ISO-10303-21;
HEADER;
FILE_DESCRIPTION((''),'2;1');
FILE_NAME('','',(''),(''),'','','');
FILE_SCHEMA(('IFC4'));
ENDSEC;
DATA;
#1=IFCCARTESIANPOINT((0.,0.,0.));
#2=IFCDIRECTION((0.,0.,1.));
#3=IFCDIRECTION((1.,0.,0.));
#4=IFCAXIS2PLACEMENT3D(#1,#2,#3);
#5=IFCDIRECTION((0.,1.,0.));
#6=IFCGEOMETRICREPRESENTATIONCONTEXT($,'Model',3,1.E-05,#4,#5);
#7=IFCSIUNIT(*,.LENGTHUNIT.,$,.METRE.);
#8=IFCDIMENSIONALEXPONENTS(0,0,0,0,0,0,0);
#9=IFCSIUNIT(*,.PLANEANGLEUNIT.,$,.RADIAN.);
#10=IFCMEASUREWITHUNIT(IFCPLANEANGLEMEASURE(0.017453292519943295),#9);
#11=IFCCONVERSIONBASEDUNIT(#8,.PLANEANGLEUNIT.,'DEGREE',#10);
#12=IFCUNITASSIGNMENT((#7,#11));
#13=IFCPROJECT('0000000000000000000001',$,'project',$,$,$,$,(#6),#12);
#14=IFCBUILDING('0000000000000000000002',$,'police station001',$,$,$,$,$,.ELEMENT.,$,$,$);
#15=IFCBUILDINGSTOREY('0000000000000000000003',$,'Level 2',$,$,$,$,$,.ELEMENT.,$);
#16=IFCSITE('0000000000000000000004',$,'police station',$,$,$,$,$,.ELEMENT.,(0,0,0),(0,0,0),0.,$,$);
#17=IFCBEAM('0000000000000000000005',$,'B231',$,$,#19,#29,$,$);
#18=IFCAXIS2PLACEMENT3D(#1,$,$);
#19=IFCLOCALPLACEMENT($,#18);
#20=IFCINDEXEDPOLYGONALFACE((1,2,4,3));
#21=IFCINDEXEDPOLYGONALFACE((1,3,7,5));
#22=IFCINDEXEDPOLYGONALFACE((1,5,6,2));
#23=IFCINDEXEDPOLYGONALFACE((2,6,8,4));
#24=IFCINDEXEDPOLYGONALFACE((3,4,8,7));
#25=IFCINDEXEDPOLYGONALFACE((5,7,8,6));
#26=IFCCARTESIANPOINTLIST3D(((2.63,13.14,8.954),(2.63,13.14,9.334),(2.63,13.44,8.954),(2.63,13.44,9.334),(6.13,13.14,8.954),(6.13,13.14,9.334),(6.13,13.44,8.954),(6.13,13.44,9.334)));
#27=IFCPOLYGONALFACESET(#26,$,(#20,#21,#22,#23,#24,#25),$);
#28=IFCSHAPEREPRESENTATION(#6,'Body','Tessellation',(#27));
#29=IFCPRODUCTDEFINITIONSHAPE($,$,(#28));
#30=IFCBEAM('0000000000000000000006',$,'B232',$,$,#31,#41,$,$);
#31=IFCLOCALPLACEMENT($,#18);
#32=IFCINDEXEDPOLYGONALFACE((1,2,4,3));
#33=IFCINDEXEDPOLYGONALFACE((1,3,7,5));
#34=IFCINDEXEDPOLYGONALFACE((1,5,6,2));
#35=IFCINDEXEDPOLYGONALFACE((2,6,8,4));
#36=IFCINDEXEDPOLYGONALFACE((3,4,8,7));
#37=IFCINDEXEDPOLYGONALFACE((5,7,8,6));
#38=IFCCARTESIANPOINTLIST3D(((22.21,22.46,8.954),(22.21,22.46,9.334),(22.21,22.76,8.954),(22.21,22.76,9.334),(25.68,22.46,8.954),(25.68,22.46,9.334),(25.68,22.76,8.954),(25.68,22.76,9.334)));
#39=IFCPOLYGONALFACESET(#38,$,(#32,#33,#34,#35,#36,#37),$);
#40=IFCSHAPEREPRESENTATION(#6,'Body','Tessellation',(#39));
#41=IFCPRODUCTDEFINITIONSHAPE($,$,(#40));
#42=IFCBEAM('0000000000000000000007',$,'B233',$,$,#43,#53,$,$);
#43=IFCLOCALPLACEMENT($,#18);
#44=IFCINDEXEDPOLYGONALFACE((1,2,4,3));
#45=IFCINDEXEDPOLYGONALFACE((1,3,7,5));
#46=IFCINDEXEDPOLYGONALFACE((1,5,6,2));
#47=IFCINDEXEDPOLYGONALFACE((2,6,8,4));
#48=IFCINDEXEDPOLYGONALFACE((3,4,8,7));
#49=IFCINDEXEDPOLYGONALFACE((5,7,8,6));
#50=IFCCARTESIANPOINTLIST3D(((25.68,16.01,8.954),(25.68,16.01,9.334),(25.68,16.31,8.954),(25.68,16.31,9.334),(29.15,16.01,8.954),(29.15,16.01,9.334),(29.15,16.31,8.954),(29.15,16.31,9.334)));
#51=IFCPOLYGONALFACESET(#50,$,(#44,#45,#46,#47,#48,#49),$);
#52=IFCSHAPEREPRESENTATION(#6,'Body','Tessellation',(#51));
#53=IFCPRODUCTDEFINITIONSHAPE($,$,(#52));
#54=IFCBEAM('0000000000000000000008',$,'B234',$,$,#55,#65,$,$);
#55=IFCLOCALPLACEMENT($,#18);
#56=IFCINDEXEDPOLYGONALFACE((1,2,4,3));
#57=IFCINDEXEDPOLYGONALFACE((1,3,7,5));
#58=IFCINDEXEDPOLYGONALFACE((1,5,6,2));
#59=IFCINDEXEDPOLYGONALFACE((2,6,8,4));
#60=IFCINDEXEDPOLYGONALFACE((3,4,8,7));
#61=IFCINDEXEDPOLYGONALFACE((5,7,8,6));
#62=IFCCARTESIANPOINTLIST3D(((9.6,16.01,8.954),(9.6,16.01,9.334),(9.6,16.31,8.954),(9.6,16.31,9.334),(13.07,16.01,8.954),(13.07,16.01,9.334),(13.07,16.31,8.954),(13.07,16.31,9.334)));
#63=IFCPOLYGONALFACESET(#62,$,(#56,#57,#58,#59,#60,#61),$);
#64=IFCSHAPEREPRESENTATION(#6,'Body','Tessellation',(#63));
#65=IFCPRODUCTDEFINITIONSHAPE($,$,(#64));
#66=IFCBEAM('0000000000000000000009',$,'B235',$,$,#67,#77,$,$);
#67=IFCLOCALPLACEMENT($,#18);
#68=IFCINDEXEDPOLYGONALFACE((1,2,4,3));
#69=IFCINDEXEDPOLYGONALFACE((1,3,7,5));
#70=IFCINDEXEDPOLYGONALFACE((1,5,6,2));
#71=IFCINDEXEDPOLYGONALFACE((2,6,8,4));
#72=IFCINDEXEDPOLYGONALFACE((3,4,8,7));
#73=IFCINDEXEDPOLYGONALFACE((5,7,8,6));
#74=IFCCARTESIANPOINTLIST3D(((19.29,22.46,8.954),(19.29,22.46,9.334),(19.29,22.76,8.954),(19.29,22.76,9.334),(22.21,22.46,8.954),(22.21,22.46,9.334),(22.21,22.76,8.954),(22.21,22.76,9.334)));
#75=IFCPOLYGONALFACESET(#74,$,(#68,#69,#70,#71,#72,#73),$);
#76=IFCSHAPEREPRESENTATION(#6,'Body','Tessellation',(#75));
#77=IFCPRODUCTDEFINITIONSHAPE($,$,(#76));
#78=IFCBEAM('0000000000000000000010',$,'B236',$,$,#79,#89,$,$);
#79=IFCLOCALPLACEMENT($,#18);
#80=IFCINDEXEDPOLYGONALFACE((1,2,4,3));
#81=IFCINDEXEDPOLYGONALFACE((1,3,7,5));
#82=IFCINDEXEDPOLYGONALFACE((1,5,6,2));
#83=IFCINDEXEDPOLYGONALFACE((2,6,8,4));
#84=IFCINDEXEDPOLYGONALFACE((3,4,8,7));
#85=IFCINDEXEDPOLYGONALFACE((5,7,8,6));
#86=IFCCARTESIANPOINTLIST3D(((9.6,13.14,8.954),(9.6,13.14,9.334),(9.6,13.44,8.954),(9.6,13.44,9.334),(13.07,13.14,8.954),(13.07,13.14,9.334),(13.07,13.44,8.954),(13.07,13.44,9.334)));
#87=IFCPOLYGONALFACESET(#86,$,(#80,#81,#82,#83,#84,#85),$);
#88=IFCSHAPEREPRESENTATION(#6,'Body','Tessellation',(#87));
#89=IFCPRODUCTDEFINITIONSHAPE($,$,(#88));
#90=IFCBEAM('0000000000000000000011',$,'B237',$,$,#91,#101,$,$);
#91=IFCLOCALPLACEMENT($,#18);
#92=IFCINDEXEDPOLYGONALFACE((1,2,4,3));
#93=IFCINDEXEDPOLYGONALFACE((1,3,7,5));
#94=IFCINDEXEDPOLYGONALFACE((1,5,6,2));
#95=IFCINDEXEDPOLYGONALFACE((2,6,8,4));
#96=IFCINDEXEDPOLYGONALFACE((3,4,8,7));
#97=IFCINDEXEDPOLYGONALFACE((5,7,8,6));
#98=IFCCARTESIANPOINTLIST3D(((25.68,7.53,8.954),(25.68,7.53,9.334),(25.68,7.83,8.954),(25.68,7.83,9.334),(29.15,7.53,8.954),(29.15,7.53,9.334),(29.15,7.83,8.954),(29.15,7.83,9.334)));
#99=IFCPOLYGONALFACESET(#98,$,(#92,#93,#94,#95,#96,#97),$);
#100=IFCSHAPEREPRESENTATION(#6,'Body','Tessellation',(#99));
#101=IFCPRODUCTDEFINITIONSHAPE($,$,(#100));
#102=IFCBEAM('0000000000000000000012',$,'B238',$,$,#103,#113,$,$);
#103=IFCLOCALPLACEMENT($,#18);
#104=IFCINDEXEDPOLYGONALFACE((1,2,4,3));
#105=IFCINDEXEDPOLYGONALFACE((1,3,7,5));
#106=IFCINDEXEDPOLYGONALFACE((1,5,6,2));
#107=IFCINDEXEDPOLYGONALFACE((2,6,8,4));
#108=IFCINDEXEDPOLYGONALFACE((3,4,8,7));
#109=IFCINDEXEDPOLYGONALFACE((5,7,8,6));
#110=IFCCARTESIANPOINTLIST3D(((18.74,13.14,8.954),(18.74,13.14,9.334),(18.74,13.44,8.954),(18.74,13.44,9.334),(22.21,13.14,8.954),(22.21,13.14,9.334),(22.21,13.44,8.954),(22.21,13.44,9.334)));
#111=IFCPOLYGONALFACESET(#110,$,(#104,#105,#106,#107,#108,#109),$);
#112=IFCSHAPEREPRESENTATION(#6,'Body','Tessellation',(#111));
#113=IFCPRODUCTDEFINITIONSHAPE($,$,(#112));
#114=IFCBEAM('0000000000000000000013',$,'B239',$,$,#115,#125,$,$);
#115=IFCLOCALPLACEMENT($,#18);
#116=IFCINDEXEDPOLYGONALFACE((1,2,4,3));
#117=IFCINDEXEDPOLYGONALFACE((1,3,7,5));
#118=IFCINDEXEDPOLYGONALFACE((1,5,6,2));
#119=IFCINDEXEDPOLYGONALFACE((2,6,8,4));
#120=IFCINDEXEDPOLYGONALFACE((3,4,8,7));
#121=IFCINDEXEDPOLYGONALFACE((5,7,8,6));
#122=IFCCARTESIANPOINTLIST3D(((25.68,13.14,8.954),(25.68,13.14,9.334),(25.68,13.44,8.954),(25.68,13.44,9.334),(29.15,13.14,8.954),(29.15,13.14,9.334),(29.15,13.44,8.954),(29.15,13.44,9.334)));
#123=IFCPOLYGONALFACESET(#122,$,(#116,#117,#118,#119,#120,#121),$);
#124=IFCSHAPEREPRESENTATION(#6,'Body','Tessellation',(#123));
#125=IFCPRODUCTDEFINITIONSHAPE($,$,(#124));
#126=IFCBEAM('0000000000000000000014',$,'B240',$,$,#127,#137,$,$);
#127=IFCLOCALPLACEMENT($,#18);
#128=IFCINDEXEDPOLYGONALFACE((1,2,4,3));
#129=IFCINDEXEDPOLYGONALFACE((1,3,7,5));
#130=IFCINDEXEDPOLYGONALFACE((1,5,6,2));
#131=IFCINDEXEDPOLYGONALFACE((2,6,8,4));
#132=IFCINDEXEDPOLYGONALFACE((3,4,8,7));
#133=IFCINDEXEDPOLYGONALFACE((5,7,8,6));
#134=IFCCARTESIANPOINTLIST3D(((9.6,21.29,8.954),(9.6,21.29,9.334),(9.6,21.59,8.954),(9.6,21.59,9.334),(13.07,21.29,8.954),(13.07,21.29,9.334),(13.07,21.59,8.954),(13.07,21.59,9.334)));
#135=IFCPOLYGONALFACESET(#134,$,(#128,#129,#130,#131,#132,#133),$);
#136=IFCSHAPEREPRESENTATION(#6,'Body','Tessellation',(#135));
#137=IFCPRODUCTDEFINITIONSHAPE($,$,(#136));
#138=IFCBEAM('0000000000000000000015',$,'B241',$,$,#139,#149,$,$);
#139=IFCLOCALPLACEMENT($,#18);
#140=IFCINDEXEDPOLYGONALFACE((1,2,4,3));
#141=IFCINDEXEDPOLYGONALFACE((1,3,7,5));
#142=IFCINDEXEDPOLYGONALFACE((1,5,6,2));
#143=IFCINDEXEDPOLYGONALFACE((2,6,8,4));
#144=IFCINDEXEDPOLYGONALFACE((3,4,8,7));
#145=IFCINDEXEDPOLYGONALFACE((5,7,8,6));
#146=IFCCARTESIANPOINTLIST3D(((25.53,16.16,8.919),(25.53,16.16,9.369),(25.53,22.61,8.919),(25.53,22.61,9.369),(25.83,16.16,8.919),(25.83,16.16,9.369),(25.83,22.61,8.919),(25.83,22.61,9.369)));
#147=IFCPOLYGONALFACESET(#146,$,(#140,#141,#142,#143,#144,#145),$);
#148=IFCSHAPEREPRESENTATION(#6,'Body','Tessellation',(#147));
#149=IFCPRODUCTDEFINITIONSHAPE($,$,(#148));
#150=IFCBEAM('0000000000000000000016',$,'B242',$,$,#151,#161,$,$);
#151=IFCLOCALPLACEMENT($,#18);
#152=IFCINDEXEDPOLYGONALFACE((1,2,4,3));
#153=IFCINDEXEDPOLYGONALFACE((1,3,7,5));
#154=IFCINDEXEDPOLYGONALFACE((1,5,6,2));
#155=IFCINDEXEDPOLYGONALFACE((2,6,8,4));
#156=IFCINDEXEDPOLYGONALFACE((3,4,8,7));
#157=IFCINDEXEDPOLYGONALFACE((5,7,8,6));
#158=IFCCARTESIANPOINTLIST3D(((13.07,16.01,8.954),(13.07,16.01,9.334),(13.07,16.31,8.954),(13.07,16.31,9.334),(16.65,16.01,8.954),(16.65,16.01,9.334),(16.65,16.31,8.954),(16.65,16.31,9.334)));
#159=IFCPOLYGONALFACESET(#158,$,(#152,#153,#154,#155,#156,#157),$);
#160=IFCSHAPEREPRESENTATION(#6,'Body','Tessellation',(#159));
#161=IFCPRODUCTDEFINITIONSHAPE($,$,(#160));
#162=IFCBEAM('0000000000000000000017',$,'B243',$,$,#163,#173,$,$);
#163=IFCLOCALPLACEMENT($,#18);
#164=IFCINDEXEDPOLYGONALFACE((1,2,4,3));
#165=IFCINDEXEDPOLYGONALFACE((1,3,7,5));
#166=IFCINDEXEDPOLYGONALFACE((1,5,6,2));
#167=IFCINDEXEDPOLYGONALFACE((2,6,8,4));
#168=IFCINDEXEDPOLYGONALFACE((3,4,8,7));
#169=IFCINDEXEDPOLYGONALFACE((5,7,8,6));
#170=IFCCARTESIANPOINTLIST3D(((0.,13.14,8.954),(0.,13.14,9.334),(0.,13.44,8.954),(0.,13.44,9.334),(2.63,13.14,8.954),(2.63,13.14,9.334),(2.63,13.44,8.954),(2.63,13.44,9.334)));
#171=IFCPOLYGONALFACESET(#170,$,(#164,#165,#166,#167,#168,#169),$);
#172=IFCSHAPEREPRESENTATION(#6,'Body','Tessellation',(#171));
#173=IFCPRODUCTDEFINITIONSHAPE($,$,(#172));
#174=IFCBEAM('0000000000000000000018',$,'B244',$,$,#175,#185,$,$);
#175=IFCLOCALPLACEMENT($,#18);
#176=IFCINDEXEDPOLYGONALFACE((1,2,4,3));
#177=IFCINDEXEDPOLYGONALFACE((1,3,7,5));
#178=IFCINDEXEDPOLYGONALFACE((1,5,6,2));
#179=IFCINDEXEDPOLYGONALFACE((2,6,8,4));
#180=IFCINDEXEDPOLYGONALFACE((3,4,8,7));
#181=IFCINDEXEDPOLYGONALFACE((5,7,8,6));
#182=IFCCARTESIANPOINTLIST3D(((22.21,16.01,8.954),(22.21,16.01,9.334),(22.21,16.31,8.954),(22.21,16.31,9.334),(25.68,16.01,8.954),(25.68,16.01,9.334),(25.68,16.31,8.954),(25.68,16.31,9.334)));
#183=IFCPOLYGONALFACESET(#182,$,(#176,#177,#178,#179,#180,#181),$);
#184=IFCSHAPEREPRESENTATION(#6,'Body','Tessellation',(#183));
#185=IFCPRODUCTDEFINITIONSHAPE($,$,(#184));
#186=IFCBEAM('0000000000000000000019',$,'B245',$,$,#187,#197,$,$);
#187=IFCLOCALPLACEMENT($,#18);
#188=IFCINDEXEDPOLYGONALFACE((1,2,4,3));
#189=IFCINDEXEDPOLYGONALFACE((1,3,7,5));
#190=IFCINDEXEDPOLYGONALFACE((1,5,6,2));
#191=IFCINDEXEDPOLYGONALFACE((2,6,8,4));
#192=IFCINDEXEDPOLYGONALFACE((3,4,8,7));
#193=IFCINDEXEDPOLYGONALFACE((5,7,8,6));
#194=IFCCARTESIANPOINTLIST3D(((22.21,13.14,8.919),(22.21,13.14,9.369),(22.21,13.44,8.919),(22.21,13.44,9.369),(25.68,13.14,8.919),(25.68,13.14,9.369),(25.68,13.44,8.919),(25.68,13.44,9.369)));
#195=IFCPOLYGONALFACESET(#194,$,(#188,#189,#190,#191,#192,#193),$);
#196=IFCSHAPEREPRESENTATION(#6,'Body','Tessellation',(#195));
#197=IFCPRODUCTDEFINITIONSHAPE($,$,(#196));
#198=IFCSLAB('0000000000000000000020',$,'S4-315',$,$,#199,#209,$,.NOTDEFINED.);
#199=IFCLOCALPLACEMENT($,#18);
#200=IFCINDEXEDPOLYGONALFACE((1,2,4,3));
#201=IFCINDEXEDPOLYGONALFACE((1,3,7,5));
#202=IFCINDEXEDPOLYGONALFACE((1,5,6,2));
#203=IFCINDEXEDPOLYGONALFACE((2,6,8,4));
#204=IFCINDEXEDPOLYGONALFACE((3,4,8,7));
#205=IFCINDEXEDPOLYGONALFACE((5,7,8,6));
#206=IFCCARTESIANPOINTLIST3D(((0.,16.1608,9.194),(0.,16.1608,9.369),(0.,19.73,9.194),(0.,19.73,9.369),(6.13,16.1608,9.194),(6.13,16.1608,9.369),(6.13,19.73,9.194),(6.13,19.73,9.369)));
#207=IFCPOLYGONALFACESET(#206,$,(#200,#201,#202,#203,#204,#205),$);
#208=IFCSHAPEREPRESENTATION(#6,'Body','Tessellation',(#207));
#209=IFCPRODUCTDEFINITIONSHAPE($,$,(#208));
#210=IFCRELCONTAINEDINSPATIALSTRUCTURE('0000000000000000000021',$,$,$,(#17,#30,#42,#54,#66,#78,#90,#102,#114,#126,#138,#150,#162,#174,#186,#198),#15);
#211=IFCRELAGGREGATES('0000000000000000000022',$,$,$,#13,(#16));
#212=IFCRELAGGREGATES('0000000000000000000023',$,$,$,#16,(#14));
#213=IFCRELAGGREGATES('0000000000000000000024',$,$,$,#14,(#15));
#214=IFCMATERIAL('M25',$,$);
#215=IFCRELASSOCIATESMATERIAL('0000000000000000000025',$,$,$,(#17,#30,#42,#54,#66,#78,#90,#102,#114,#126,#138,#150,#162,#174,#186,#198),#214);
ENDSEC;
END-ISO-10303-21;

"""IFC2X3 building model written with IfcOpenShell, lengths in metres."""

from ifc_helpers import new_model, entity, si_unit, converted_unit, direction, frame, frame_2d, origin_with_axes, place, context, project, spatial, rectangle, extrude, material, element, save


model = new_model("IFC2X3")

# Units and contexts
model_context = context("Model", 3, precision=1e-05, world=origin_with_axes(), true_north=direction((0.0, 1.0, 0.0)))
ifc_project = project(units=[si_unit("LENGTHUNIT", "METRE"), converted_unit("PLANEANGLEUNIT", "DEGREE", entity("IfcPlaneAngleMeasure", 0.017453292519943295), si_unit("PLANEANGLEUNIT", "RADIAN"), dimensions=[0, 0, 0, 0, 0, 0, 0])], contexts=[model_context])

# Site, building, storey
site = spatial("IfcSite", under=ifc_project, Name="police station", CompositionType="ELEMENT", RefLatitude=(0, 0, 0), RefLongitude=(0, 0, 0), RefElevation=0.0)
building = spatial("IfcBuilding", under=site, Name="police station001", CompositionType="ELEMENT")
storey = spatial("IfcBuildingStorey", under=building, Name="Level 2", CompositionType="ELEMENT")

# Shared definitions
ifc_material = material(Name="M25")
placement = place(None, origin_with_axes())

# Beams
element("IfcBeam", 1, at=placement, inside=storey, material=ifc_material, Name="B231", context=model_context, shape_type="SweptSolid", body=[
    extrude(rectangle(XDim=0.3, YDim=0.38, at=frame_2d((0.0, 0.0), x_axis=(0.0, 1.0, 0.0))), frame((2.63, 13.29, 9.144), z_axis=(1.0, 0.0, 0.0), x_axis=(0.0, 0.0, -1.0)), (0.0, 0.0, 1.0), 3.5),
])
element("IfcBeam", 2, at=placement, inside=storey, material=ifc_material, Name="B232", context=model_context, shape_type="SweptSolid", body=[
    extrude(rectangle(XDim=0.3, YDim=0.38, at=frame_2d((0.0, 0.0), x_axis=(0.0, 1.0, 0.0))), frame((25.68, 22.61, 9.144), z_axis=(-1.0, 0.0, 0.0), x_axis=(0.0, 0.0, -1.0)), (0.0, 0.0, 1.0), 3.47),
])
element("IfcBeam", 3, at=placement, inside=storey, material=ifc_material, Name="B233", context=model_context, shape_type="SweptSolid", body=[
    extrude(rectangle(XDim=0.3, YDim=0.38, at=frame_2d((0.0, 0.0), x_axis=(0.0, 1.0, 0.0))), frame((25.68, 16.16, 9.144), z_axis=(1.0, 0.0, 0.0), x_axis=(0.0, 0.0, -1.0)), (0.0, 0.0, 1.0), 3.47),
])
element("IfcBeam", 4, at=placement, inside=storey, material=ifc_material, Name="B234", context=model_context, shape_type="SweptSolid", body=[
    extrude(rectangle(XDim=0.3, YDim=0.38, at=frame_2d((0.0, 0.0), x_axis=(0.0, 1.0, 0.0))), frame((13.07, 16.16, 9.144), z_axis=(-1.0, 0.0, 0.0), x_axis=(0.0, 0.0, -1.0)), (0.0, 0.0, 1.0), 3.47),
])
element("IfcBeam", 5, at=placement, inside=storey, material=ifc_material, Name="B235", context=model_context, shape_type="SweptSolid", body=[
    extrude(rectangle(XDim=0.3, YDim=0.38, at=frame_2d((0.0, 0.0), x_axis=(0.0, 1.0, 0.0))), frame((22.21, 22.61, 9.144), z_axis=(-1.0, 0.0, 0.0), x_axis=(0.0, 0.0, -1.0)), (0.0, 0.0, 1.0), 2.92),
])
element("IfcBeam", 6, at=placement, inside=storey, material=ifc_material, Name="B236", context=model_context, shape_type="SweptSolid", body=[
    extrude(rectangle(XDim=0.3, YDim=0.38, at=frame_2d((0.0, 0.0), x_axis=(0.0, 1.0, 0.0))), frame((13.07, 13.29, 9.144), z_axis=(-1.0, 0.0, 0.0), x_axis=(0.0, 0.0, -1.0)), (0.0, 0.0, 1.0), 3.47),
])
element("IfcBeam", 7, at=placement, inside=storey, material=ifc_material, Name="B237", context=model_context, shape_type="SweptSolid", body=[
    extrude(rectangle(XDim=0.3, YDim=0.38, at=frame_2d((0.0, 0.0), x_axis=(0.0, 1.0, 0.0))), frame((25.68, 7.68, 9.144), z_axis=(1.0, 0.0, 0.0), x_axis=(0.0, 0.0, -1.0)), (0.0, 0.0, 1.0), 3.47),
])
element("IfcBeam", 8, at=placement, inside=storey, material=ifc_material, Name="B238", context=model_context, shape_type="SweptSolid", body=[
    extrude(rectangle(XDim=0.3, YDim=0.38, at=frame_2d((0.0, 0.0), x_axis=(0.0, 1.0, 0.0))), frame((22.21, 13.29, 9.144), z_axis=(-1.0, 0.0, 0.0), x_axis=(0.0, 0.0, -1.0)), (0.0, 0.0, 1.0), 3.47),
])
element("IfcBeam", 9, at=placement, inside=storey, material=ifc_material, Name="B239", context=model_context, shape_type="SweptSolid", body=[
    extrude(rectangle(XDim=0.3, YDim=0.38, at=frame_2d((0.0, 0.0), x_axis=(0.0, 1.0, 0.0))), frame((29.15, 13.29, 9.144), z_axis=(-1.0, 0.0, 0.0), x_axis=(0.0, 0.0, -1.0)), (0.0, 0.0, 1.0), 3.47),
])
element("IfcBeam", 10, at=placement, inside=storey, material=ifc_material, Name="B240", context=model_context, shape_type="SweptSolid", body=[
    extrude(rectangle(XDim=0.3, YDim=0.38, at=frame_2d((0.0, 0.0), x_axis=(0.0, 1.0, 0.0))), frame((13.07, 21.44, 9.144), z_axis=(-1.0, 0.0, 0.0), x_axis=(0.0, 0.0, -1.0)), (0.0, 0.0, 1.0), 3.47),
])
element("IfcBeam", 11, at=placement, inside=storey, material=ifc_material, Name="B241", context=model_context, shape_type="SweptSolid", body=[
    extrude(rectangle(XDim=0.3, YDim=0.45, at=frame_2d((0.0, 0.0), x_axis=(0.0, 1.0, 0.0))), frame((25.68, 22.61, 9.144), z_axis=(0.0, -1.0, 0.0), x_axis=(0.0, 0.0, -1.0)), (0.0, 0.0, 1.0), 6.45),
])
element("IfcBeam", 12, at=placement, inside=storey, material=ifc_material, Name="B242", context=model_context, shape_type="SweptSolid", body=[
    extrude(rectangle(XDim=0.3, YDim=0.38, at=frame_2d((0.0, 0.0), x_axis=(0.0, 1.0, 0.0))), frame((16.65, 16.16, 9.144), z_axis=(-1.0, 0.0, 0.0), x_axis=(0.0, 0.0, -1.0)), (0.0, 0.0, 1.0), 3.58),
])
element("IfcBeam", 13, at=placement, inside=storey, material=ifc_material, Name="B243", context=model_context, shape_type="SweptSolid", body=[
    extrude(rectangle(XDim=0.3, YDim=0.38, at=frame_2d((0.0, 0.0), x_axis=(0.0, 1.0, 0.0))), frame((0.0, 13.29, 9.144), z_axis=(1.0, 0.0, 0.0), x_axis=(0.0, 0.0, -1.0)), (0.0, 0.0, 1.0), 2.63),
])
element("IfcBeam", 14, at=placement, inside=storey, material=ifc_material, Name="B244", context=model_context, shape_type="SweptSolid", body=[
    extrude(rectangle(XDim=0.3, YDim=0.38, at=frame_2d((0.0, 0.0), x_axis=(0.0, 1.0, 0.0))), frame((22.21, 16.16, 9.144), z_axis=(1.0, 0.0, 0.0), x_axis=(0.0, 0.0, -1.0)), (0.0, 0.0, 1.0), 3.47),
])
element("IfcBeam", 15, at=placement, inside=storey, material=ifc_material, Name="B245", context=model_context, shape_type="SweptSolid", body=[
    extrude(rectangle(XDim=0.3, YDim=0.45, at=frame_2d((0.0, 0.0), x_axis=(0.0, 1.0, 0.0))), frame((25.68, 13.29, 9.144), z_axis=(-1.0, 0.0, 0.0), x_axis=(0.0, 0.0, -1.0)), (0.0, 0.0, 1.0), 3.47),
])

# Slab
element("IfcSlab", 16, at=placement, inside=storey, material=ifc_material, Name="S4-315", PredefinedType="NOTDEFINED", context=model_context, shape_type="SweptSolid", body=[
    extrude(rectangle(XDim=6.13, YDim=3.5692, at=frame_2d((0.0, 0.0), x_axis=(1.0, 0.0, 0.0))), frame((3.065, 17.9454, 9.194), z_axis=(0.0, 0.0, 1.0), x_axis=(1.0, 0.0, 0.0)), (0.0, 0.0, 1.0), 0.175),
])

save(model, "model.ifc")
